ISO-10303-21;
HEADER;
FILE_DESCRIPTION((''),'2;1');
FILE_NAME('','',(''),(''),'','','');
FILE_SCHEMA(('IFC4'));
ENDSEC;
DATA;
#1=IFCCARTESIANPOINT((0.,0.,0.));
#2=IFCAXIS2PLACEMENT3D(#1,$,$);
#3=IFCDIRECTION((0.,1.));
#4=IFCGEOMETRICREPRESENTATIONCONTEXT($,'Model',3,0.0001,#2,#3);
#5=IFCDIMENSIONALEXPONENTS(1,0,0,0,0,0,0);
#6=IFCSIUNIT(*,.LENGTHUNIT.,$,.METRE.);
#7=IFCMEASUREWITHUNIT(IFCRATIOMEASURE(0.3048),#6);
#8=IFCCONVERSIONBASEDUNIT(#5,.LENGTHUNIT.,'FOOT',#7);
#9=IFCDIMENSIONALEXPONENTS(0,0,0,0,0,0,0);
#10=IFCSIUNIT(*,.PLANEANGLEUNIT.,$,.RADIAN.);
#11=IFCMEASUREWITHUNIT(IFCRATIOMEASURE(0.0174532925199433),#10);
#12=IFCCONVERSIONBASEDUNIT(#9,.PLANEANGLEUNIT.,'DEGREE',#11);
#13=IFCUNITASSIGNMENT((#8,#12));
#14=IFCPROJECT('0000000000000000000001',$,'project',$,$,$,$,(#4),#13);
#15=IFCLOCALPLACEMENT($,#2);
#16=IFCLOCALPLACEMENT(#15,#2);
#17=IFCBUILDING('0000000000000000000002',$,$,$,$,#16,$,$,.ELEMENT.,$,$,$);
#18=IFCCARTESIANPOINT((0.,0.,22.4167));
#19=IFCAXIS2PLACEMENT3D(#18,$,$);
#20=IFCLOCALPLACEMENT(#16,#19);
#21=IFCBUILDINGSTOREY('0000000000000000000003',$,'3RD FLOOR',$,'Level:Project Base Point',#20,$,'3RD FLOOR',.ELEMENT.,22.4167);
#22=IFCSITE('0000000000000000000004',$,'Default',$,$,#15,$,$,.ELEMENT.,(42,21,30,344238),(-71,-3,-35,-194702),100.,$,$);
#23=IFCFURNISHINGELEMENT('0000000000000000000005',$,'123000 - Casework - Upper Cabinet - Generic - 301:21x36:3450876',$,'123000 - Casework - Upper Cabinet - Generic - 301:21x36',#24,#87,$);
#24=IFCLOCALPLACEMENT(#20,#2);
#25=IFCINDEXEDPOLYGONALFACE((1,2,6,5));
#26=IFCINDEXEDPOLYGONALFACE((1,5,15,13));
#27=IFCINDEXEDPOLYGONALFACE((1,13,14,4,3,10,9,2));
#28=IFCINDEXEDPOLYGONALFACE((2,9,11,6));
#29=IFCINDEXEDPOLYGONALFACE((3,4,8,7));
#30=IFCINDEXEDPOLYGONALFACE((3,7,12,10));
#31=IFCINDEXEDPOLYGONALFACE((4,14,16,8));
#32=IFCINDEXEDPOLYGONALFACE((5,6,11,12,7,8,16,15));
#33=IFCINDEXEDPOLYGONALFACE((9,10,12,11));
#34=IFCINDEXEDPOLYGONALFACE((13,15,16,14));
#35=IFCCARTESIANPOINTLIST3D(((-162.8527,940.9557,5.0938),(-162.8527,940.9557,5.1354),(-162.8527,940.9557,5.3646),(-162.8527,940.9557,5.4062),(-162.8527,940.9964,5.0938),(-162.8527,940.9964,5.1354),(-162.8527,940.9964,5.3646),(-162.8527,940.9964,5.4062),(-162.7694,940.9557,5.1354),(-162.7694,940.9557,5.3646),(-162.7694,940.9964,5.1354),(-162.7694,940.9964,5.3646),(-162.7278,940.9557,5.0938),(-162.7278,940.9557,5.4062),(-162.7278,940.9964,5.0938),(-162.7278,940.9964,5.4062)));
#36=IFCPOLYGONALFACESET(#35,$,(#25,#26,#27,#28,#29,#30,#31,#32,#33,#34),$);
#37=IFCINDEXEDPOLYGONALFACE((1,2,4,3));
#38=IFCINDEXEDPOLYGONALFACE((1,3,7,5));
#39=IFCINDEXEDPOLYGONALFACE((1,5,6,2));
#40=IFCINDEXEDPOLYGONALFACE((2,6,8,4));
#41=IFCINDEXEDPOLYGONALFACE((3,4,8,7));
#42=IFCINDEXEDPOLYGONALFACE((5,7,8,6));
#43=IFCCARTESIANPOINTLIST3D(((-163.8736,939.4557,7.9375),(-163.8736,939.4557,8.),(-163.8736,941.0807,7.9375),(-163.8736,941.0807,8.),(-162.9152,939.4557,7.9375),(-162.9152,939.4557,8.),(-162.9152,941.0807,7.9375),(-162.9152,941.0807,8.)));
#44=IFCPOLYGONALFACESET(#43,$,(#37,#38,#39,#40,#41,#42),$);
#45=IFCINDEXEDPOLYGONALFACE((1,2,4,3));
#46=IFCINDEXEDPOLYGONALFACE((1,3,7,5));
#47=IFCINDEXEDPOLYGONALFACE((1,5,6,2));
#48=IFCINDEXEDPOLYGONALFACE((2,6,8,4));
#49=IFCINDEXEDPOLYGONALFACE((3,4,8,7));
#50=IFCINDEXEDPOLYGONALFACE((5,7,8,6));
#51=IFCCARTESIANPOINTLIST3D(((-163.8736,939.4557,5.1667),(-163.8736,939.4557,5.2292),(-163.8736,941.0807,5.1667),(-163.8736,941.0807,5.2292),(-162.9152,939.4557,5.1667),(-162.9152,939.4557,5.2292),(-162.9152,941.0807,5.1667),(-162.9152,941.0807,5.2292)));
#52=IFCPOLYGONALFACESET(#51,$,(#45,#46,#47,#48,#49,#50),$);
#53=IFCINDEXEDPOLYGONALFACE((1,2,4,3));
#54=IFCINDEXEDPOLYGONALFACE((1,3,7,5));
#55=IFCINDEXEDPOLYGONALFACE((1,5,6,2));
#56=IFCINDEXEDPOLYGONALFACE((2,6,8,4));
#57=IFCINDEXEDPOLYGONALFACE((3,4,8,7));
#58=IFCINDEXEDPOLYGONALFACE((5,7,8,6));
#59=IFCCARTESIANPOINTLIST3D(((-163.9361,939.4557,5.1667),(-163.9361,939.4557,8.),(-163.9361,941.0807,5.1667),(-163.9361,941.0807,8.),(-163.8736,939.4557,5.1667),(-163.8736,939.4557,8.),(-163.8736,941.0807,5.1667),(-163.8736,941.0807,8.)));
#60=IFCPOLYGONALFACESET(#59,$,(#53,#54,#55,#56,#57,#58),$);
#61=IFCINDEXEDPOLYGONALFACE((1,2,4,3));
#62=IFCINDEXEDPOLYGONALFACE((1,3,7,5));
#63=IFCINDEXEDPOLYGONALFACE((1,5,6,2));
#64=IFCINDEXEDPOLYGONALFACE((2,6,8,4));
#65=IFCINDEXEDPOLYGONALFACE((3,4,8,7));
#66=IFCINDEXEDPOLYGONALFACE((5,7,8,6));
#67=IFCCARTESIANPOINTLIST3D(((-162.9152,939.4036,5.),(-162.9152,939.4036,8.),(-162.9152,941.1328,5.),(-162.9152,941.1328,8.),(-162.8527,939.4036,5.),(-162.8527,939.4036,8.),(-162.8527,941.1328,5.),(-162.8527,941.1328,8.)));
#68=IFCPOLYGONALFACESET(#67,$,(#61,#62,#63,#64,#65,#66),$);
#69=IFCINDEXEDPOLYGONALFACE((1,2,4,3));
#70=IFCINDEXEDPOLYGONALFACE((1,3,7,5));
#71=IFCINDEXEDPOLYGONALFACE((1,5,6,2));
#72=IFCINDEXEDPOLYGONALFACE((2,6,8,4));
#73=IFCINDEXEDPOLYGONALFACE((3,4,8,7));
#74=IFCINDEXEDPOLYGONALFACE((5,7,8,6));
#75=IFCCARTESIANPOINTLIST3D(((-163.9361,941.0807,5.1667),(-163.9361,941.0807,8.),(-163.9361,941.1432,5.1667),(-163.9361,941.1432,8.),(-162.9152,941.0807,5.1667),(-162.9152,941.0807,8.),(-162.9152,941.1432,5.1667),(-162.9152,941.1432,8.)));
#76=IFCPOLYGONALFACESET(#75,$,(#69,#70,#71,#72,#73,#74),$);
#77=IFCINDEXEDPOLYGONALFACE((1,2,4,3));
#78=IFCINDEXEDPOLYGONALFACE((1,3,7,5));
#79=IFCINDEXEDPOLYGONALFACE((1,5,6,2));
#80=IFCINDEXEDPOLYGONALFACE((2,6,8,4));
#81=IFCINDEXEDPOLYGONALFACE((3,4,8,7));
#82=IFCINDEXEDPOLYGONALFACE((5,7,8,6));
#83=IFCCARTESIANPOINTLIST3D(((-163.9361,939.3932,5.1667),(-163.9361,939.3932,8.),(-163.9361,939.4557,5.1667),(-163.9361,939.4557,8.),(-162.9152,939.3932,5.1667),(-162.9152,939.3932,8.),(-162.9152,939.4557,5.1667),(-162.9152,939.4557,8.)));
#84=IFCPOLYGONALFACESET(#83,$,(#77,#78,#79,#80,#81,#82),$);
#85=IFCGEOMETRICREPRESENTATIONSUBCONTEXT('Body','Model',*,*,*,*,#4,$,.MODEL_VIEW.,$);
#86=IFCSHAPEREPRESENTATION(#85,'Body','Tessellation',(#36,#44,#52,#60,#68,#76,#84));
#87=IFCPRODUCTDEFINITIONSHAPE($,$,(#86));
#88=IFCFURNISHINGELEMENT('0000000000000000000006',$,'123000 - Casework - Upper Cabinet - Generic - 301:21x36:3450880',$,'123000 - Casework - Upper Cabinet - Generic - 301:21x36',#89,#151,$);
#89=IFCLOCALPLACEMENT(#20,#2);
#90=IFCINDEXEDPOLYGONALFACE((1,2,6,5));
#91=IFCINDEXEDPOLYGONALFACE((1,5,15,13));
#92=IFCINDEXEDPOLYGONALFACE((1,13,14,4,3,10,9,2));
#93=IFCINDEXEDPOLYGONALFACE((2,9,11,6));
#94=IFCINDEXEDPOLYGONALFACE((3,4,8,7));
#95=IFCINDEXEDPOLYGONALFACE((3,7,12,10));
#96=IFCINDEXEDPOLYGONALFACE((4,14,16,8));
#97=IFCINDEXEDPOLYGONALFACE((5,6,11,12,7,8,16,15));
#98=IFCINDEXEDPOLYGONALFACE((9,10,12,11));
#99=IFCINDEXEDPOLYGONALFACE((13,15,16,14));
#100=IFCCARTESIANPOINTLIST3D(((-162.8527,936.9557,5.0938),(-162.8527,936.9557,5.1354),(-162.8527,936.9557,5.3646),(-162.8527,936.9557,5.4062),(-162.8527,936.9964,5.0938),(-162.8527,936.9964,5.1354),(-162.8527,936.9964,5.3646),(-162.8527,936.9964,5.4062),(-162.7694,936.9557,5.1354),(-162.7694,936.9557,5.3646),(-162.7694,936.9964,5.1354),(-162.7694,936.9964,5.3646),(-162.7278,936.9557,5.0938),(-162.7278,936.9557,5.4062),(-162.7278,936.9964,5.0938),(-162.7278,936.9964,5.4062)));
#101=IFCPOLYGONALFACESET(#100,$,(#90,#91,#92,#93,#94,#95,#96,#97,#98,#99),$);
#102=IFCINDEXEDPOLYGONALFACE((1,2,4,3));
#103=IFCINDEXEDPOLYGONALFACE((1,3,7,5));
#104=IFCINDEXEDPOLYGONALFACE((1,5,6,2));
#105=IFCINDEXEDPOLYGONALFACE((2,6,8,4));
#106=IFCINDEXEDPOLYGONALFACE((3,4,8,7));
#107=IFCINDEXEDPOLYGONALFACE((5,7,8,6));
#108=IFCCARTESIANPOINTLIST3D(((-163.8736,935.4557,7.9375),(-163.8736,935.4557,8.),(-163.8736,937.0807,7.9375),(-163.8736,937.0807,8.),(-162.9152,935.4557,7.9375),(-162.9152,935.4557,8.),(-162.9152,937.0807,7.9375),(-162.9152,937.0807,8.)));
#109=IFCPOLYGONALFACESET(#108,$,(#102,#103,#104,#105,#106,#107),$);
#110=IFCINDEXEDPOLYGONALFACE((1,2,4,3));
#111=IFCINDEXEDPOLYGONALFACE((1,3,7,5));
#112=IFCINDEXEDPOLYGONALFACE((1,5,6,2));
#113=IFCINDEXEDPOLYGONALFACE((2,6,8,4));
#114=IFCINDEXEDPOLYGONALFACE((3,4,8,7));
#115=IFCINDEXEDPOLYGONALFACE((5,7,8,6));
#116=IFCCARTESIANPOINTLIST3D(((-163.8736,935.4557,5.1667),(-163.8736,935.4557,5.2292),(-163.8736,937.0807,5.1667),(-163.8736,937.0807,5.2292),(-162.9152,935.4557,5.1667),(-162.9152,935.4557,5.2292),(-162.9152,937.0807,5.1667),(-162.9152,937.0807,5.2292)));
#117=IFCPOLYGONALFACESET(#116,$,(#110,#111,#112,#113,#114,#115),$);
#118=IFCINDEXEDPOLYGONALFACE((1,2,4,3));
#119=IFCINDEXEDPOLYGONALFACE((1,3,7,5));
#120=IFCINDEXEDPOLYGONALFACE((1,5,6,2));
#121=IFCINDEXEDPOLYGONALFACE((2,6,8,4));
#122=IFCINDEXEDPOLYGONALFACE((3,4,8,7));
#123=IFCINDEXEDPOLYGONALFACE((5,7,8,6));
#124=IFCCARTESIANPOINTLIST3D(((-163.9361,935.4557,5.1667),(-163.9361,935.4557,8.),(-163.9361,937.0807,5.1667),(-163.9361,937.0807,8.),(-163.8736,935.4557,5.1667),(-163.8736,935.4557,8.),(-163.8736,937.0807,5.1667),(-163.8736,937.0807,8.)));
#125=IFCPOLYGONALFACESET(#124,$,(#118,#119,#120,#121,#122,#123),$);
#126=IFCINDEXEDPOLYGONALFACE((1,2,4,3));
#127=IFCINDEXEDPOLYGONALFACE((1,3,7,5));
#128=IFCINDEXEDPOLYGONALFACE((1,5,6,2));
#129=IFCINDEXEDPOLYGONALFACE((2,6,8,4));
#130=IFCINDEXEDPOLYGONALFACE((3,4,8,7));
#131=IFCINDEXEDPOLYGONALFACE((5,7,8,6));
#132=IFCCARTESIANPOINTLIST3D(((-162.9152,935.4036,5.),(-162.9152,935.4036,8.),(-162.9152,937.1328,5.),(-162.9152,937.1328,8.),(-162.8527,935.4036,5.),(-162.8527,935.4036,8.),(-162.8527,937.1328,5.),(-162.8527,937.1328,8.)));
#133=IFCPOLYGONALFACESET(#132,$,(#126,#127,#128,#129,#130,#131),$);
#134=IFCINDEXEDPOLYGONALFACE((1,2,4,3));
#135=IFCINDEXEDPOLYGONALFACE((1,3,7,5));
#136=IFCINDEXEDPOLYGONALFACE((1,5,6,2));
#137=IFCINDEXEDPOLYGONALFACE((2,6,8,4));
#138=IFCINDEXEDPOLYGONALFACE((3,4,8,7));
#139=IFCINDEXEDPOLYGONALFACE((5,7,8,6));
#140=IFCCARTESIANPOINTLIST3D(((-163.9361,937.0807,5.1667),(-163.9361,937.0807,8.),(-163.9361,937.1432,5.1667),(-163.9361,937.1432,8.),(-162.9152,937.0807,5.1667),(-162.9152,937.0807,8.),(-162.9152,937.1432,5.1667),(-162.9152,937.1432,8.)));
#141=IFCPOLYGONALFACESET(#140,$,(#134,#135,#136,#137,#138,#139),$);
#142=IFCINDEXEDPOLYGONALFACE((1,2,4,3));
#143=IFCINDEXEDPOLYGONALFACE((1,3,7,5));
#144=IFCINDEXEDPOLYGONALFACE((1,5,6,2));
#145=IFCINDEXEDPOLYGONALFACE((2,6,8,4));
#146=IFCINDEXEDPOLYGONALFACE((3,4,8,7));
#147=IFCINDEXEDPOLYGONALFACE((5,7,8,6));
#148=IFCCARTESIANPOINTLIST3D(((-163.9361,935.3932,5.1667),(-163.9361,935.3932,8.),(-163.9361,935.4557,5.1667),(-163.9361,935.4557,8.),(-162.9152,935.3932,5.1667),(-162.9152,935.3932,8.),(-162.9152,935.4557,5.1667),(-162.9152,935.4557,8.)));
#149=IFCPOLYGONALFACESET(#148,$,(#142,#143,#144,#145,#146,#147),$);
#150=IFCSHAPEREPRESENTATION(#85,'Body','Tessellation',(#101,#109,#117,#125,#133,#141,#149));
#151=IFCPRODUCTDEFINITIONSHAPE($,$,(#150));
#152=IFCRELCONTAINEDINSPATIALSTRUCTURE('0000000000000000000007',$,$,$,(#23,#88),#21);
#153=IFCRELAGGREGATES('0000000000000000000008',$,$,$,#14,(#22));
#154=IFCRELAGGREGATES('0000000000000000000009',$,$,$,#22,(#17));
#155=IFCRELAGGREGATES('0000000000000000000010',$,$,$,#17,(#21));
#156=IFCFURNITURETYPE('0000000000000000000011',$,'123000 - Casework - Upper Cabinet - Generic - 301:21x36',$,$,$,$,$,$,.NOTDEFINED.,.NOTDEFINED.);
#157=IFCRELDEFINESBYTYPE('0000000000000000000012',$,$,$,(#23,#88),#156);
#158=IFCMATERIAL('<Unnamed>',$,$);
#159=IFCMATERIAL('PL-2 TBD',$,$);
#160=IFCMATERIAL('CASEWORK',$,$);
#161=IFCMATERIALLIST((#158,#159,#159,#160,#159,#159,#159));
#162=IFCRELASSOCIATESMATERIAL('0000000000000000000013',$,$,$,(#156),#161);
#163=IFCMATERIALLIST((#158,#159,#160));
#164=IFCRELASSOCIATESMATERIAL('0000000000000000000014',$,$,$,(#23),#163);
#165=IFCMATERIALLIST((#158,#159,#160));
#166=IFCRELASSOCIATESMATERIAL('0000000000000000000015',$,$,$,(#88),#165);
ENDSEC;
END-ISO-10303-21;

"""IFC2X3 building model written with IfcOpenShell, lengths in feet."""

from ifc_helpers import new_model, entity, si_unit, converted_unit, direction, frame, frame_2d, origin, origin_2d_with_axis, place, context, subcontext, project, spatial, polyline, rectangle, outline, extrude, source, transform, mapped, material, material_list, type_object, type_shapes, element, save


model = new_model("IFC2X3")

# Units and contexts
model_context = context("Model", 3, precision=0.0001, world=origin(), true_north=direction((0.0, 1.0)))
body_context = subcontext(model_context, "Body", "Model", "MODEL_VIEW")
ifc_project = project(units=[converted_unit("LENGTHUNIT", "FOOT", entity("IfcRatioMeasure", 0.3048), si_unit("LENGTHUNIT", "METRE"), dimensions=[1, 0, 0, 0, 0, 0, 0]), converted_unit("PLANEANGLEUNIT", "DEGREE", entity("IfcRatioMeasure", 0.0174532925199433), si_unit("PLANEANGLEUNIT", "RADIAN"), dimensions=[0, 0, 0, 0, 0, 0, 0])], contexts=[model_context])

# Site, building, storey
site_placement = place(None, origin())
site = spatial("IfcSite", under=ifc_project, at=site_placement, Name="Default", CompositionType="ELEMENT", RefLatitude=(42, 21, 30, 344238), RefLongitude=(-71, -3, -35, -194702), RefElevation=100.0)
building_placement = place(site_placement, origin())
building = spatial("IfcBuilding", under=site, at=building_placement, CompositionType="ELEMENT")
storey_placement = place(building_placement, frame((0.0, 0.0, 22.4167)))
storey = spatial("IfcBuildingStorey", under=building, at=storey_placement, Name="3RD FLOOR", ObjectType="Level:Project Base Point", LongName="3RD FLOOR", CompositionType="ELEMENT", Elevation=22.4167)

# Furnishing elements
ifc_material_1 = material(Name="CASEWORK")
ifc_material_2 = material(Name="<Unnamed>")
ifc_material_3 = material(Name="PL-2 TBD")
ifc_material_list_1 = material_list([ifc_material_2, ifc_material_3, ifc_material_1])
ifc_material_list_2 = material_list([ifc_material_2, ifc_material_3, ifc_material_3, ifc_material_1, ifc_material_3, ifc_material_3, ifc_material_3])
furniture_type_1 = type_object("IfcFurnitureType", Name="123000 - Casework - Upper Cabinet - Generic - 301:21x36", material=ifc_material_list_2)
shared_shape_1 = source(origin(), body_context, "Body", "SweptSolid", [
    extrude(outline(polyline([(-0.0521, -0.1146), (-0.0521, -0.1562), (0.0729, -0.1562), (0.0729, 0.1562), (-0.0521, 0.1562), (-0.0521, 0.1146), (0.0313, 0.1146), (0.0313, -0.1146), (-0.0521, -0.1146)])), frame((0.1468, 1.1354, 0.25), z_axis=(-1.0, 0.0, 0.0), x_axis=(0.0, 1.0, 0.0)), (0.0, 0.0, -1.0), 0.0407),
    extrude(rectangle(XDim=0.9583, YDim=1.625, at=frame_2d((0.0, 0.0), x_axis=(1.0, 0.0))), frame((0.875, 0.5417, 2.9375), z_axis=(0.0, 0.0, 1.0), x_axis=(0.0, 1.0, 0.0)), (0.0, 0.0, 1.0), 0.0625),
    extrude(rectangle(XDim=0.9583, YDim=1.625, at=frame_2d((0.0, 0.0), x_axis=(1.0, 0.0))), frame((0.875, 0.5417, 0.1667), z_axis=(0.0, 0.0, 1.0), x_axis=(0.0, 1.0, 0.0)), (0.0, 0.0, 1.0), 0.0625),
    extrude(rectangle(XDim=1.625, YDim=0.0625, at=origin_2d_with_axis()), frame((0.875, 0.0313, 0.1667), z_axis=(0.0, 0.0, 1.0), x_axis=(-1.0, 0.0, 0.0)), (0.0, 0.0, 1.0), 2.8333),
    extrude(rectangle(XDim=1.7292, YDim=0.0625, at=frame_2d((0.0, 0.0), x_axis=(1.0, 0.0))), frame((0.875, 1.0521, 0.0)), (0.0, 0.0, 1.0), 3.0),
    extrude(rectangle(XDim=1.0208, YDim=0.0625, at=origin_2d_with_axis()), frame((0.0312, 0.5104, 0.1667), z_axis=(0.0, 0.0, 1.0), x_axis=(0.0, 1.0, 0.0)), (0.0, 0.0, 1.0), 2.8333),
    extrude(rectangle(XDim=1.0208, YDim=0.0625, at=origin_2d_with_axis()), frame((1.7188, 0.5104, 0.1667), z_axis=(0.0, 0.0, 1.0), x_axis=(0.0, 1.0, 0.0)), (0.0, 0.0, 1.0), 2.8333),
])
type_shapes(furniture_type_1, [shared_shape_1])
furnishing_1_placement = place(storey_placement, frame((-163.9361, 941.1432, 5.0), z_axis=(0.0, 0.0, 1.0), x_axis=(0.0, -1.0, 0.0)))
element("IfcFurnishingElement", 1, at=furnishing_1_placement, inside=storey, type_object=furniture_type_1, material=ifc_material_list_1, Name="123000 - Casework - Upper Cabinet - Generic - 301:21x36:3450876", ObjectType="123000 - Casework - Upper Cabinet - Generic - 301:21x36", context=body_context, shape_type="MappedRepresentation", body=[
    mapped(shared_shape_1, transform((0.0, 0.0, 0.0), scale=1.0)),
])
ifc_material_list_3 = material_list([ifc_material_2, ifc_material_3, ifc_material_1])
furnishing_2_placement = place(storey_placement, frame((-163.9361, 937.1432, 5.0), z_axis=(0.0, 0.0, 1.0), x_axis=(0.0, -1.0, 0.0)))
element("IfcFurnishingElement", 2, at=furnishing_2_placement, inside=storey, type_object=furniture_type_1, material=ifc_material_list_3, Name="123000 - Casework - Upper Cabinet - Generic - 301:21x36:3450880", ObjectType="123000 - Casework - Upper Cabinet - Generic - 301:21x36", context=body_context, shape_type="MappedRepresentation", body=[
    mapped(shared_shape_1, transform((0.0, 0.0, 0.0), scale=1.0)),
])

save(model, "model.ifc")
